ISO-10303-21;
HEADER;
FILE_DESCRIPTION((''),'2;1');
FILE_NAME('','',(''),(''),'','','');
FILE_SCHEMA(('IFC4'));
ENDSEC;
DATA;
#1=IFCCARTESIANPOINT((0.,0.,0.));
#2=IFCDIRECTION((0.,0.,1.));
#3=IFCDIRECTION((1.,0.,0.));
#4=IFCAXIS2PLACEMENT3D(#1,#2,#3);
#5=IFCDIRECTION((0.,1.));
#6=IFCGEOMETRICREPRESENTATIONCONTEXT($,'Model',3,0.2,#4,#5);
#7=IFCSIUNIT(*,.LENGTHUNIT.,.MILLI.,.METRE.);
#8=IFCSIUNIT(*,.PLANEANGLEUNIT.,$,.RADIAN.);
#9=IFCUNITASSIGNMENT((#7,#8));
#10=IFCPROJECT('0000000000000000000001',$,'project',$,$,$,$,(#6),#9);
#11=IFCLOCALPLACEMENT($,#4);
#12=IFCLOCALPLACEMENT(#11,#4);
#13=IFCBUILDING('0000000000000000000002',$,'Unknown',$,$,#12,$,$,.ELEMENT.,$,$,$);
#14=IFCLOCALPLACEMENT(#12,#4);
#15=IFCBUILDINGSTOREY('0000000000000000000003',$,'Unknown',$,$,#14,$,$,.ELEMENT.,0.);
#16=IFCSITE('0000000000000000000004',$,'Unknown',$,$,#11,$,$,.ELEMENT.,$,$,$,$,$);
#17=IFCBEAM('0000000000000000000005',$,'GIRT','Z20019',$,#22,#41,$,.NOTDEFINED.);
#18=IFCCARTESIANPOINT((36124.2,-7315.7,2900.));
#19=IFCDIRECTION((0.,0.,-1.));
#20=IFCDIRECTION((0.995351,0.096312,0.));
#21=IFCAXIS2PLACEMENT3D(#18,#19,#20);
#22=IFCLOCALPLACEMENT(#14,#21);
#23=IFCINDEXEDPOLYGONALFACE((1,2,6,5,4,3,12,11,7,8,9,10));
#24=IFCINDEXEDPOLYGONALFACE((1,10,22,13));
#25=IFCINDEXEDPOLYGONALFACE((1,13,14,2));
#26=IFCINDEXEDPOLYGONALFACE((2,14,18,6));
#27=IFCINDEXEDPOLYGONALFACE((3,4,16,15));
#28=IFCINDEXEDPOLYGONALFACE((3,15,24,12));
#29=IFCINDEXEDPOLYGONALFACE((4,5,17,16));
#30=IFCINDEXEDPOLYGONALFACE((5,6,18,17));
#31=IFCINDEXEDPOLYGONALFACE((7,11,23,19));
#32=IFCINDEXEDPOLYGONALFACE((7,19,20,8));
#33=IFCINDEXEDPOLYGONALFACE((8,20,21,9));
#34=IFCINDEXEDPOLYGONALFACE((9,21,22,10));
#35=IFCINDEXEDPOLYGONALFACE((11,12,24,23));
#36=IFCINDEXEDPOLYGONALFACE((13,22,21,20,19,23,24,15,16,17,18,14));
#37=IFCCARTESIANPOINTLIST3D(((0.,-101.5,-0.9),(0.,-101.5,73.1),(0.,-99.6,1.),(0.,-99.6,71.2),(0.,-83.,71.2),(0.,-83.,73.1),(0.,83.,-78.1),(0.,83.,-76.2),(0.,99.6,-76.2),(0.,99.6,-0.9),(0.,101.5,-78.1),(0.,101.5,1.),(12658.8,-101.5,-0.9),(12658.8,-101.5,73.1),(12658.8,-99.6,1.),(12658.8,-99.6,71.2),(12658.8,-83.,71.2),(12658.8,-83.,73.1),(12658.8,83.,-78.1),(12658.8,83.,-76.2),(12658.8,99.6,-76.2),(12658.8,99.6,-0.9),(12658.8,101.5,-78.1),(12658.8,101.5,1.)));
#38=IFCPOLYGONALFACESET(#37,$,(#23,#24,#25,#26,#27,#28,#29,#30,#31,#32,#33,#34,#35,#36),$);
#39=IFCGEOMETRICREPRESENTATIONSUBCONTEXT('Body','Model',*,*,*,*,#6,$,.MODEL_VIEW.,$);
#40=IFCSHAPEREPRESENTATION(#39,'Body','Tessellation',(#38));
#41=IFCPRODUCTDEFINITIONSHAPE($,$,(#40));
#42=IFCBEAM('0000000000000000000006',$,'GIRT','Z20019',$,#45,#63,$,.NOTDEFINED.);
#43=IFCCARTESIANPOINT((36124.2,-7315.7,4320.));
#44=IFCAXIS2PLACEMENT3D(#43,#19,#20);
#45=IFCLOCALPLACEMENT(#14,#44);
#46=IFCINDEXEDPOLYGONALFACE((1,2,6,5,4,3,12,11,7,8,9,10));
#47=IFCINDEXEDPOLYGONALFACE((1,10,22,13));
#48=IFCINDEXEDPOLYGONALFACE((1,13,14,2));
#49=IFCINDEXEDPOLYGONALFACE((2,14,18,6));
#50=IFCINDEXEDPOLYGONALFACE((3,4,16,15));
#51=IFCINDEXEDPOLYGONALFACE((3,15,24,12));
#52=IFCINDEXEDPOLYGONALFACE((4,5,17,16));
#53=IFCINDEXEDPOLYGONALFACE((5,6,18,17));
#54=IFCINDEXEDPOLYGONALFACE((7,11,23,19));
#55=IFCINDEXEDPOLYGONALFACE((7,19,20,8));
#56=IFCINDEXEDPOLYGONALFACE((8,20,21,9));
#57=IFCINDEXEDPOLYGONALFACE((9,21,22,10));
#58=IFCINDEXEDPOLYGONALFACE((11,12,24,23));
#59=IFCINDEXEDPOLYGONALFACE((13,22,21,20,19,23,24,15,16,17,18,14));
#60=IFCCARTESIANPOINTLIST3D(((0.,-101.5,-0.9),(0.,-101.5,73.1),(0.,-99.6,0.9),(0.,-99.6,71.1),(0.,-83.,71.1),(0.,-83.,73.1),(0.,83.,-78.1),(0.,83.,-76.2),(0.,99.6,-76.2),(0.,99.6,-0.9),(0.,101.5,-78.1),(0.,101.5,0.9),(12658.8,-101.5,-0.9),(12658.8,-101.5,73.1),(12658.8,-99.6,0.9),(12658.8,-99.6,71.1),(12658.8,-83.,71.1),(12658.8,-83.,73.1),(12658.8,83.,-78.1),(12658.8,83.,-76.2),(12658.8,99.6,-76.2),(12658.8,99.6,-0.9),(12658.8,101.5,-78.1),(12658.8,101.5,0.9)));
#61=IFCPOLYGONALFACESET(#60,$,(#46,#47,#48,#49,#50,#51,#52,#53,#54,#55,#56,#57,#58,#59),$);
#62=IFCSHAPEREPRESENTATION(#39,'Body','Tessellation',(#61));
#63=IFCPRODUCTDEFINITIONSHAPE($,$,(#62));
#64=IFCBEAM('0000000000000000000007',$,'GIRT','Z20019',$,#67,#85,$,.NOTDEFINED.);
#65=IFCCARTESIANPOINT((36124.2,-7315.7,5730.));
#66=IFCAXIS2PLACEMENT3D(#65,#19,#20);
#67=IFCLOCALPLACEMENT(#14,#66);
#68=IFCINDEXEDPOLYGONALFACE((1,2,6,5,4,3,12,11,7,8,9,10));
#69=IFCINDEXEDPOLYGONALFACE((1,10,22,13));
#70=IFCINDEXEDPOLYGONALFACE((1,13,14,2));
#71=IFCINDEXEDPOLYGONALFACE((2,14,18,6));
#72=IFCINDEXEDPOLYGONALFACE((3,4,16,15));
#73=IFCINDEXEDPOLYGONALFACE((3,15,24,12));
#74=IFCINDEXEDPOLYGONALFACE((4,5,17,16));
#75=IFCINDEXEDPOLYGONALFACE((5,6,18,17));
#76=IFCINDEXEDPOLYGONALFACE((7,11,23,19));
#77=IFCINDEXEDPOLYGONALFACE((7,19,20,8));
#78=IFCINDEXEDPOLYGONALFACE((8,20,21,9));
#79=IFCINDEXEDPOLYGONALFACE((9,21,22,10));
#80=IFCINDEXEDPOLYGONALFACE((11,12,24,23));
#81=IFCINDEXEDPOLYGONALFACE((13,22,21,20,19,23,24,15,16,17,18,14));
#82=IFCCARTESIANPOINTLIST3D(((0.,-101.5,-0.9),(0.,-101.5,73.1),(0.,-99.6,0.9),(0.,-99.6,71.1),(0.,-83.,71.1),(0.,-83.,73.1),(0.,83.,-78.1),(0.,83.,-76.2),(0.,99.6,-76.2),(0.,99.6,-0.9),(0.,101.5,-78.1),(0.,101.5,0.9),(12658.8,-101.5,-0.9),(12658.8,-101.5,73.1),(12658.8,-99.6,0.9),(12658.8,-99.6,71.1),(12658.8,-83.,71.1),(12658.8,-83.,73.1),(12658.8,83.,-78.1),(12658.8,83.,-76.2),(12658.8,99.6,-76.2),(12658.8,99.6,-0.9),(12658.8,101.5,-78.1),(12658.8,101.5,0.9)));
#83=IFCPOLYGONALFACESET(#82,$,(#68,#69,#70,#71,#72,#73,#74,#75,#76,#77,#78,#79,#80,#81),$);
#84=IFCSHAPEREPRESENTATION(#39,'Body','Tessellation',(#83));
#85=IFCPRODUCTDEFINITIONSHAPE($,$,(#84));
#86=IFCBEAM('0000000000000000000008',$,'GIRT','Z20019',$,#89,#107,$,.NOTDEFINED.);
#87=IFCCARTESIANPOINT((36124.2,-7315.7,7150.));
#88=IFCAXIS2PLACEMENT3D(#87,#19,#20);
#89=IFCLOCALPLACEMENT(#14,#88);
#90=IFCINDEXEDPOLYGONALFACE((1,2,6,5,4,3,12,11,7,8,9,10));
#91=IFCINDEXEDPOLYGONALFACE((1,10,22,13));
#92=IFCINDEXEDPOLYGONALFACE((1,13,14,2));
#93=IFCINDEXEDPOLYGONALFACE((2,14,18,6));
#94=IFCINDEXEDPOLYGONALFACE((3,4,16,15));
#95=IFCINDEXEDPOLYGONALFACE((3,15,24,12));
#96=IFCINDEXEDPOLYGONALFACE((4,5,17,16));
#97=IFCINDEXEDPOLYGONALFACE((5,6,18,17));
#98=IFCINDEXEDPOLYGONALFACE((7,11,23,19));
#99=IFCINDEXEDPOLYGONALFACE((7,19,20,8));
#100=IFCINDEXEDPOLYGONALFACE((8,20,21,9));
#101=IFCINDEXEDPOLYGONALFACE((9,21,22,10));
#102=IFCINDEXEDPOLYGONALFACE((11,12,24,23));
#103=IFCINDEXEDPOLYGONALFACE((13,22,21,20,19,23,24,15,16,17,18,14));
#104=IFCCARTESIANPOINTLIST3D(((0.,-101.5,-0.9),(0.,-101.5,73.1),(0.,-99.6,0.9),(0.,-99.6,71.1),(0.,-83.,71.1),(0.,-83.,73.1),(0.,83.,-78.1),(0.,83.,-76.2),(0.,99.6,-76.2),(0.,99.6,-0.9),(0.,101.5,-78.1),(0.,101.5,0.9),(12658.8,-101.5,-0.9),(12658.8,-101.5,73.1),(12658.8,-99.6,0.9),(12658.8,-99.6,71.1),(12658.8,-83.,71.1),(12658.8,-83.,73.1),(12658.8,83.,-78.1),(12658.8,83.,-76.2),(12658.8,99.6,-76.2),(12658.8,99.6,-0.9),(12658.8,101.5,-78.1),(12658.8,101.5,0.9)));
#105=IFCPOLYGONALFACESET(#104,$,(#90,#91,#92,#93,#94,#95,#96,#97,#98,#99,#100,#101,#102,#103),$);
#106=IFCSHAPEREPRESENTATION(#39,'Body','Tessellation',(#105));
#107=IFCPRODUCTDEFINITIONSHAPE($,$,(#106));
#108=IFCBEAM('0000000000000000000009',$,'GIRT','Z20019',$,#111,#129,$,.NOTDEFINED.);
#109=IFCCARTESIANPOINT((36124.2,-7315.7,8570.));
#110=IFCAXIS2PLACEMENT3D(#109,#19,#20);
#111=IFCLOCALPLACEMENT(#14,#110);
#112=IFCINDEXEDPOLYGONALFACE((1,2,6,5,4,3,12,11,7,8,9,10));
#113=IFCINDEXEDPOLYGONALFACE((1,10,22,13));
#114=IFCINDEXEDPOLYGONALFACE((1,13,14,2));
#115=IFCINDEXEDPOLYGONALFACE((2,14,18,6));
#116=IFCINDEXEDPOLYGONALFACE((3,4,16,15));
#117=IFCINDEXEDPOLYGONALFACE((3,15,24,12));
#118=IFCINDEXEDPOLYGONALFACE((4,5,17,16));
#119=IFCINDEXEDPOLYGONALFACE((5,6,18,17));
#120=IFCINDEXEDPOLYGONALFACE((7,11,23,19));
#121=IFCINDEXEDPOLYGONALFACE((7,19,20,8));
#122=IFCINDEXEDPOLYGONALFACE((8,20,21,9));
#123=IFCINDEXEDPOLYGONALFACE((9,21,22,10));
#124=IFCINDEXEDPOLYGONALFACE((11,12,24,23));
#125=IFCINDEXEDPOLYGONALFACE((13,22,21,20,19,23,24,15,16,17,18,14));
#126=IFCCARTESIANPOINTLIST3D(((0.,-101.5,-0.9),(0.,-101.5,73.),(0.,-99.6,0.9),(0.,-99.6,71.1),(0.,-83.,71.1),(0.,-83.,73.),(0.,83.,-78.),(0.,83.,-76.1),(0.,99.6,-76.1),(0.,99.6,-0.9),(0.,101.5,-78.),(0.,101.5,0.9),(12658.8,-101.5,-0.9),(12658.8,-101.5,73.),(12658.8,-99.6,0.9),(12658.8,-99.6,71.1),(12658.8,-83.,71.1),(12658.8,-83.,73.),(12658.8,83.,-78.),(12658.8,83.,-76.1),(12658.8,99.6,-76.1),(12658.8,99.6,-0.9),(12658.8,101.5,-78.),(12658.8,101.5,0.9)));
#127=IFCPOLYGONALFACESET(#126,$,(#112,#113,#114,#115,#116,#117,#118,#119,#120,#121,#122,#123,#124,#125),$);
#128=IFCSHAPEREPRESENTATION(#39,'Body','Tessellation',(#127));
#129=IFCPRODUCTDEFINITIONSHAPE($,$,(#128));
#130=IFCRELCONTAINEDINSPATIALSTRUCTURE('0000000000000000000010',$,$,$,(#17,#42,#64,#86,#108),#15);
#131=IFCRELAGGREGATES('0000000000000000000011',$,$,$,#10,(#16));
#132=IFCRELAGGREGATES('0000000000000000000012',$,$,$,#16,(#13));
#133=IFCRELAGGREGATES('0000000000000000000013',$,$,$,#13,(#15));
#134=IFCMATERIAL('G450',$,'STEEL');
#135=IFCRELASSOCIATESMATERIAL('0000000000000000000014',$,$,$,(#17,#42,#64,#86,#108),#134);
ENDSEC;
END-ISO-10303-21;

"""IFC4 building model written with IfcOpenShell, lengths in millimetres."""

from ifc_helpers import new_model, si_unit, direction, frame, origin_with_axes, place, context, subcontext, project, spatial, line, indexed_curve, outline, extrude, material, element, save


model = new_model("IFC4")

# Units and contexts
model_context = context("Model", 3, precision=0.2, world=origin_with_axes(), true_north=direction((0.0, 1.0)))
body_context = subcontext(model_context, "Body", "Model", "MODEL_VIEW")
ifc_project = project(units=[si_unit("LENGTHUNIT", "METRE", prefix="MILLI"), si_unit("PLANEANGLEUNIT", "RADIAN")], contexts=[model_context])

# Site, building, storey
site_placement = place(None, origin_with_axes())
site = spatial("IfcSite", under=ifc_project, at=site_placement, Name="Unknown", CompositionType="ELEMENT")
building_placement = place(site_placement, origin_with_axes())
building = spatial("IfcBuilding", under=site, at=building_placement, Name="Unknown", CompositionType="ELEMENT")
storey_placement = place(building_placement, origin_with_axes())
storey = spatial("IfcBuildingStorey", under=building, at=storey_placement, Name="Unknown", CompositionType="ELEMENT", Elevation=0.0)

# Shared definitions
ifc_material_1 = material(Name="G450", Category="STEEL")

# Beams
for number, where, z_axis, x_axis, name in (
    (1, (36124.2, -7315.7, 2900.0), (0.0, 0.0, -1.0), (0.995351, 0.096312, 0.0), "GIRT"),
    (2, (36124.2, -7315.7, 4320.0), (0.0, 0.0, -1.0), (0.995351, 0.096312, 0.0), "GIRT"),
    (3, (36124.2, -7315.7, 5730.0), (0.0, 0.0, -1.0), (0.995351, 0.096312, 0.0), "GIRT"),
    (4, (36124.2, -7315.7, 7150.0), (0.0, 0.0, -1.0), (0.995351, 0.096312, 0.0), "GIRT"),
    (5, (36124.2, -7315.7, 8570.0), (0.0, 0.0, -1.0), (0.995351, 0.096312, 0.0), "GIRT"),
):
    element("IfcBeam", number, at=place(storey_placement, frame(where, z_axis=z_axis, x_axis=x_axis)), inside=storey, material=ifc_material_1, Name=name, Description="Z20019", PredefinedType="NOTDEFINED", context=body_context, shape_type="SolidModel", body=[
        extrude(outline(indexed_curve([(73.0, -101.5), (73.0, -83.0), (71.2, -83.0), (71.2, -99.6), (0.9, -99.6), (0.9, 101.5), (-78.0, 101.5), (-78.0, 83.0), (-76.2, 83.0), (-76.2, 99.6), (-0.9, 99.6), (-0.9, -101.5)], segments=[line(1, 2, 3, 4, 5, 6, 7, 8, 9, 10, 11, 12, 1)])), frame((0.0, 0.0, 0.0), z_axis=(-1.0, 0.0, 0.0), x_axis=(0.0, 0.0, 1.0)), (0.0, 0.0, -1.0), 12658.8),
    ])

save(model, "model.ifc")
